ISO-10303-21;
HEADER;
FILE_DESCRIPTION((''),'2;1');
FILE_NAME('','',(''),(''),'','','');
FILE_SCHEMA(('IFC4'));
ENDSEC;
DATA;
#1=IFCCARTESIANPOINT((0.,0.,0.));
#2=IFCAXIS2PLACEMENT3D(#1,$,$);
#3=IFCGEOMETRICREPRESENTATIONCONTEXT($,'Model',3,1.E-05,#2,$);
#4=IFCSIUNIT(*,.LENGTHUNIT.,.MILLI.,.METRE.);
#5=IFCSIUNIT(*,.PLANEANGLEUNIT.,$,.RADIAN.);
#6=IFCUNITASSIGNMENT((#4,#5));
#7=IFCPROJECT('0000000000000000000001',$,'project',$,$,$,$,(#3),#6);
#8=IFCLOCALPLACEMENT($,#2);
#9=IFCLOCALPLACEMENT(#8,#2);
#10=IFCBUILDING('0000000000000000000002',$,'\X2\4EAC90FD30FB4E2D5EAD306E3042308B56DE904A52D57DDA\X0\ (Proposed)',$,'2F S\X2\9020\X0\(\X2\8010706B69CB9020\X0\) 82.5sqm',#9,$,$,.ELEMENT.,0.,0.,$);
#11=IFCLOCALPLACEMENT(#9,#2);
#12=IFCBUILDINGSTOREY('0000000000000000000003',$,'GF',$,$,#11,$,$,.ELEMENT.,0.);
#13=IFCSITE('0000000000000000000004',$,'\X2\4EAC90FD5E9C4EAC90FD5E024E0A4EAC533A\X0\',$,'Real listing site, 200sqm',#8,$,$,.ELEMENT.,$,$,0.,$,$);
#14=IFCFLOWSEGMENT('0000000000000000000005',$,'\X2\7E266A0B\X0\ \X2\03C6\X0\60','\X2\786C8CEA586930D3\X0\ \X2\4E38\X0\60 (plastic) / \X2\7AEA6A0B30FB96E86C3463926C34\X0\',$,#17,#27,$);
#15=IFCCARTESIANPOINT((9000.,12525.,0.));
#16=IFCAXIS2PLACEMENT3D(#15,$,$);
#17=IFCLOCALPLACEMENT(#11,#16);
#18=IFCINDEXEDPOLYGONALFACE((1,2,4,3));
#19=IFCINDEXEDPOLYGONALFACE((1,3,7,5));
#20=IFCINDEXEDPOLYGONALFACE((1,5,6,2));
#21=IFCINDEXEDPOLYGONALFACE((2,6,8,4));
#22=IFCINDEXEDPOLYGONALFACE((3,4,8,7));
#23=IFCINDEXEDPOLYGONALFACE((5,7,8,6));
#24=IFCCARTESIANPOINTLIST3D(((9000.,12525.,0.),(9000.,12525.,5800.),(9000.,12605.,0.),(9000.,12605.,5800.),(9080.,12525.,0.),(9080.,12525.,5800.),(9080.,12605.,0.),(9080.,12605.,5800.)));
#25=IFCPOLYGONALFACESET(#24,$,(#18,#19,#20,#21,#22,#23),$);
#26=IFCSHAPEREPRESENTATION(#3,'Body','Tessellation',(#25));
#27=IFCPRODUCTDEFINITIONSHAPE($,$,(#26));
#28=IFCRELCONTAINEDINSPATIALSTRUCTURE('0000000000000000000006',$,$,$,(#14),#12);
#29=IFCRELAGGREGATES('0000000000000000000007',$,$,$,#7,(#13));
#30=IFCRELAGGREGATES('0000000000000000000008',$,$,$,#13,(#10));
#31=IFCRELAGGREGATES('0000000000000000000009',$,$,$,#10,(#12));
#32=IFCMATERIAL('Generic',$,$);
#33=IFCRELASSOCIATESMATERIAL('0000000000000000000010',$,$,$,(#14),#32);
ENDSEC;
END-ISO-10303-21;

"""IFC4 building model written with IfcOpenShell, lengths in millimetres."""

from ifc_helpers import new_model, si_unit, frame, frame_2d, origin, place, context, project, spatial, rectangle, extrude, material, element, save


model = new_model("IFC4")

# Units and contexts
model_context = context("Model", 3, precision=1e-05, world=origin())
ifc_project = project(units=[si_unit("LENGTHUNIT", "METRE", prefix="MILLI"), si_unit("PLANEANGLEUNIT", "RADIAN")], contexts=[model_context])

# Site, building, storey
site_placement = place(None, origin())
site = spatial("IfcSite", under=ifc_project, at=site_placement, Name="京都府京都市上京区", ObjectType="Real listing site, 200sqm", CompositionType="ELEMENT", RefElevation=0.0)
building_placement = place(site_placement, origin())
building = spatial("IfcBuilding", under=site, at=building_placement, Name="京都・中庭のある回遊動線 (Proposed)", ObjectType="2F S造(耐火構造) 82.5sqm", CompositionType="ELEMENT", ElevationOfRefHeight=0.0, ElevationOfTerrain=0.0)
storey_placement = place(building_placement, origin())
storey = spatial("IfcBuildingStorey", under=building, at=storey_placement, Name="GF", CompositionType="ELEMENT", Elevation=0.0)

# Flow segment
ifc_material_1 = material(Name="Generic")
flow_segment_placement = place(storey_placement, frame((9000.0, 12525.0, 0.0)))
element("IfcFlowSegment", 1, at=flow_segment_placement, inside=storey, material=ifc_material_1, Name="縦樋 φ60", Description="硬質塩ビ 丸60 (plastic) / 竪樋・雨水排水", context=model_context, shape_type="SweptSolid", body=[
    extrude(rectangle(XDim=80.0, YDim=80.0, at=frame_2d((40.0, 40.0))), frame((9000.0, 12525.0, 0.0)), (0.0, 0.0, 1.0), 5800.0),
])

save(model, "model.ifc")
